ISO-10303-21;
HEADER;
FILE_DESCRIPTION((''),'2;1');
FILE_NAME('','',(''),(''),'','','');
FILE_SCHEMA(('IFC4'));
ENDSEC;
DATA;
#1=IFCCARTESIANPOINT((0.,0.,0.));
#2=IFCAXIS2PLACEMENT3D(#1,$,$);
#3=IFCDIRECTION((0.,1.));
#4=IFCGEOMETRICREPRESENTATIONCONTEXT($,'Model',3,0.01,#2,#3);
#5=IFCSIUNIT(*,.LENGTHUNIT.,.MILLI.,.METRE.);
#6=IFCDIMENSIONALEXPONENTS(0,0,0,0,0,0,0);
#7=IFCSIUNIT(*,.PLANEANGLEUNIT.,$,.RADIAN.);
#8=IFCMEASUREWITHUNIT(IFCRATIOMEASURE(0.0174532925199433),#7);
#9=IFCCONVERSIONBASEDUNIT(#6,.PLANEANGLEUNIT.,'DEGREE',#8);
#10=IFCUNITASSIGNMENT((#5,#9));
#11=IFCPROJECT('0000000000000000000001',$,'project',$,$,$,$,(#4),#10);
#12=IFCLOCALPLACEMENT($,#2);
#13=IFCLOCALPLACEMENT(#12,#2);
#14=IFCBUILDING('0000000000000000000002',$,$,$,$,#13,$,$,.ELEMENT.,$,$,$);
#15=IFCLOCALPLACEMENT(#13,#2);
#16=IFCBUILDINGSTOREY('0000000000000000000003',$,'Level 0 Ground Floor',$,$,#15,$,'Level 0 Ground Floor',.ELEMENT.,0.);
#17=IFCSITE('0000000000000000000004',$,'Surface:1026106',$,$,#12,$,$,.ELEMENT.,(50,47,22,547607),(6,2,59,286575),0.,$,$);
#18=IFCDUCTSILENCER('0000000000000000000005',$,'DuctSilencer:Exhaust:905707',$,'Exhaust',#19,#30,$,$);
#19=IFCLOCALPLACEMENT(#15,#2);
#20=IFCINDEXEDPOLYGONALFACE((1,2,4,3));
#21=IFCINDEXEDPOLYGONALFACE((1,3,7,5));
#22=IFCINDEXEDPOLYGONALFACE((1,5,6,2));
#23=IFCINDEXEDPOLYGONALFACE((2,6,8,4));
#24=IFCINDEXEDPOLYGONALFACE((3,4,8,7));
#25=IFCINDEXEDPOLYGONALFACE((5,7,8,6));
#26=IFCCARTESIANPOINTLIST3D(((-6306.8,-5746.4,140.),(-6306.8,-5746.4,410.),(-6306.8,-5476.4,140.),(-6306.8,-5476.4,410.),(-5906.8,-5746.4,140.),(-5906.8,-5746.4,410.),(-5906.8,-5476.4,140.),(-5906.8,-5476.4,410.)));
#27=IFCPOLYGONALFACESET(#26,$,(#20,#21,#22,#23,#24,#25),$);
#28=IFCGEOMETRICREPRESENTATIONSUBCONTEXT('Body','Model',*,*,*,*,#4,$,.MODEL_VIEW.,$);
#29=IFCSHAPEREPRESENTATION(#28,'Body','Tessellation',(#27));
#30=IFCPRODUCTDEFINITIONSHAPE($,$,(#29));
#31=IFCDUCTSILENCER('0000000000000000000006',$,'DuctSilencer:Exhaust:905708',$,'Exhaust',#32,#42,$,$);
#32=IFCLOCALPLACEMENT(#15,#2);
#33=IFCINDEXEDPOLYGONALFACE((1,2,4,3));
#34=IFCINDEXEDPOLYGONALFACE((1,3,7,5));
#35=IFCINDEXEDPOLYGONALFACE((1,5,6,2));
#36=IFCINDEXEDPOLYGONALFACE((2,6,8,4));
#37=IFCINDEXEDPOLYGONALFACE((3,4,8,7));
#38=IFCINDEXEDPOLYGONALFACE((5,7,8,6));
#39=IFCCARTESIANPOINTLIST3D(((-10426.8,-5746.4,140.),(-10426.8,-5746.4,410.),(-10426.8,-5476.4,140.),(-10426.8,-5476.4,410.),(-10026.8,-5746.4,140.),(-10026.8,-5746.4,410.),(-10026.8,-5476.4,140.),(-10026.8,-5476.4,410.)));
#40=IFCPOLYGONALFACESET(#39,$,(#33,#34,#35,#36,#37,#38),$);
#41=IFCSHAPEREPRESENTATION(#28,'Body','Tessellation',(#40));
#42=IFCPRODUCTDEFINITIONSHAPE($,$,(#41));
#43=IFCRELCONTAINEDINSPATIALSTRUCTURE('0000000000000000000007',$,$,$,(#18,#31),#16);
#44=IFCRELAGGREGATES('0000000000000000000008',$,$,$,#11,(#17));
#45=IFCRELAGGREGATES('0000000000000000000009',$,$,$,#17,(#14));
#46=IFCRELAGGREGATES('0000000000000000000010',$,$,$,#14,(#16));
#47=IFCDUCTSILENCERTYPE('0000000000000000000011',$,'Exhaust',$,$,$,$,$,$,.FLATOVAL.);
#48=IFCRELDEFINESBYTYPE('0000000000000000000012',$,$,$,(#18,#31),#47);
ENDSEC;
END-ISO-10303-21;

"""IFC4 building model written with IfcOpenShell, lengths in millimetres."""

from ifc_helpers import new_model, entity, si_unit, converted_unit, direction, frame, origin, origin_2d_with_axis, place, context, subcontext, project, spatial, rectangle, extrude, source, transform, mapped, type_object, type_shapes, element, save


model = new_model("IFC4")

# Units and contexts
model_context = context("Model", 3, precision=0.01, world=origin(), true_north=direction((0.0, 1.0)))
body_context = subcontext(model_context, "Body", "Model", "MODEL_VIEW")
ifc_project = project(units=[si_unit("LENGTHUNIT", "METRE", prefix="MILLI"), converted_unit("PLANEANGLEUNIT", "DEGREE", entity("IfcRatioMeasure", 0.0174532925199433), si_unit("PLANEANGLEUNIT", "RADIAN"), dimensions=[0, 0, 0, 0, 0, 0, 0])], contexts=[model_context])

# Site, building, storey
site_placement = place(None, origin())
site = spatial("IfcSite", under=ifc_project, at=site_placement, Name="Surface:1026106", CompositionType="ELEMENT", RefLatitude=(50, 47, 22, 547607), RefLongitude=(6, 2, 59, 286575), RefElevation=0.0)
building_placement = place(site_placement, origin())
building = spatial("IfcBuilding", under=site, at=building_placement, CompositionType="ELEMENT")
storey_placement = place(building_placement, origin())
storey = spatial("IfcBuildingStorey", under=building, at=storey_placement, Name="Level 0 Ground Floor", LongName="Level 0 Ground Floor", CompositionType="ELEMENT", Elevation=0.0)

# Duct silencers
duct_silencer_type_1 = type_object("IfcDuctSilencerType", Name="Exhaust", PredefinedType="FLATOVAL")
shared_shape_1 = source(origin(), body_context, "Body", "SweptSolid", [
    extrude(rectangle(XDim=400.0, YDim=270.0, at=origin_2d_with_axis()), frame((0.0, 0.0, -135.0), z_axis=(0.0, 0.0, 1.0), x_axis=(-1.0, 0.0, 0.0)), (0.0, 0.0, 1.0), 270.0),
])
type_shapes(duct_silencer_type_1, [shared_shape_1])
duct_silencer_1_placement = place(storey_placement, frame((-6106.8, -5611.4, 275.0)))
element("IfcDuctSilencer", 1, at=duct_silencer_1_placement, inside=storey, type_object=duct_silencer_type_1, Name="DuctSilencer:Exhaust:905707", ObjectType="Exhaust", context=body_context, shape_type="MappedRepresentation", body=[
    mapped(shared_shape_1, transform((0.0, 0.0, 0.0), scale=1.0)),
])
duct_silencer_2_placement = place(storey_placement, frame((-10226.8, -5611.4, 275.0), z_axis=(0.0, 0.0, 1.0), x_axis=(-1.0, 0.0, 0.0)))
element("IfcDuctSilencer", 2, at=duct_silencer_2_placement, inside=storey, type_object=duct_silencer_type_1, Name="DuctSilencer:Exhaust:905708", ObjectType="Exhaust", context=body_context, shape_type="MappedRepresentation", body=[
    mapped(shared_shape_1, transform((0.0, 0.0, 0.0), scale=1.0)),
])

save(model, "model.ifc")
